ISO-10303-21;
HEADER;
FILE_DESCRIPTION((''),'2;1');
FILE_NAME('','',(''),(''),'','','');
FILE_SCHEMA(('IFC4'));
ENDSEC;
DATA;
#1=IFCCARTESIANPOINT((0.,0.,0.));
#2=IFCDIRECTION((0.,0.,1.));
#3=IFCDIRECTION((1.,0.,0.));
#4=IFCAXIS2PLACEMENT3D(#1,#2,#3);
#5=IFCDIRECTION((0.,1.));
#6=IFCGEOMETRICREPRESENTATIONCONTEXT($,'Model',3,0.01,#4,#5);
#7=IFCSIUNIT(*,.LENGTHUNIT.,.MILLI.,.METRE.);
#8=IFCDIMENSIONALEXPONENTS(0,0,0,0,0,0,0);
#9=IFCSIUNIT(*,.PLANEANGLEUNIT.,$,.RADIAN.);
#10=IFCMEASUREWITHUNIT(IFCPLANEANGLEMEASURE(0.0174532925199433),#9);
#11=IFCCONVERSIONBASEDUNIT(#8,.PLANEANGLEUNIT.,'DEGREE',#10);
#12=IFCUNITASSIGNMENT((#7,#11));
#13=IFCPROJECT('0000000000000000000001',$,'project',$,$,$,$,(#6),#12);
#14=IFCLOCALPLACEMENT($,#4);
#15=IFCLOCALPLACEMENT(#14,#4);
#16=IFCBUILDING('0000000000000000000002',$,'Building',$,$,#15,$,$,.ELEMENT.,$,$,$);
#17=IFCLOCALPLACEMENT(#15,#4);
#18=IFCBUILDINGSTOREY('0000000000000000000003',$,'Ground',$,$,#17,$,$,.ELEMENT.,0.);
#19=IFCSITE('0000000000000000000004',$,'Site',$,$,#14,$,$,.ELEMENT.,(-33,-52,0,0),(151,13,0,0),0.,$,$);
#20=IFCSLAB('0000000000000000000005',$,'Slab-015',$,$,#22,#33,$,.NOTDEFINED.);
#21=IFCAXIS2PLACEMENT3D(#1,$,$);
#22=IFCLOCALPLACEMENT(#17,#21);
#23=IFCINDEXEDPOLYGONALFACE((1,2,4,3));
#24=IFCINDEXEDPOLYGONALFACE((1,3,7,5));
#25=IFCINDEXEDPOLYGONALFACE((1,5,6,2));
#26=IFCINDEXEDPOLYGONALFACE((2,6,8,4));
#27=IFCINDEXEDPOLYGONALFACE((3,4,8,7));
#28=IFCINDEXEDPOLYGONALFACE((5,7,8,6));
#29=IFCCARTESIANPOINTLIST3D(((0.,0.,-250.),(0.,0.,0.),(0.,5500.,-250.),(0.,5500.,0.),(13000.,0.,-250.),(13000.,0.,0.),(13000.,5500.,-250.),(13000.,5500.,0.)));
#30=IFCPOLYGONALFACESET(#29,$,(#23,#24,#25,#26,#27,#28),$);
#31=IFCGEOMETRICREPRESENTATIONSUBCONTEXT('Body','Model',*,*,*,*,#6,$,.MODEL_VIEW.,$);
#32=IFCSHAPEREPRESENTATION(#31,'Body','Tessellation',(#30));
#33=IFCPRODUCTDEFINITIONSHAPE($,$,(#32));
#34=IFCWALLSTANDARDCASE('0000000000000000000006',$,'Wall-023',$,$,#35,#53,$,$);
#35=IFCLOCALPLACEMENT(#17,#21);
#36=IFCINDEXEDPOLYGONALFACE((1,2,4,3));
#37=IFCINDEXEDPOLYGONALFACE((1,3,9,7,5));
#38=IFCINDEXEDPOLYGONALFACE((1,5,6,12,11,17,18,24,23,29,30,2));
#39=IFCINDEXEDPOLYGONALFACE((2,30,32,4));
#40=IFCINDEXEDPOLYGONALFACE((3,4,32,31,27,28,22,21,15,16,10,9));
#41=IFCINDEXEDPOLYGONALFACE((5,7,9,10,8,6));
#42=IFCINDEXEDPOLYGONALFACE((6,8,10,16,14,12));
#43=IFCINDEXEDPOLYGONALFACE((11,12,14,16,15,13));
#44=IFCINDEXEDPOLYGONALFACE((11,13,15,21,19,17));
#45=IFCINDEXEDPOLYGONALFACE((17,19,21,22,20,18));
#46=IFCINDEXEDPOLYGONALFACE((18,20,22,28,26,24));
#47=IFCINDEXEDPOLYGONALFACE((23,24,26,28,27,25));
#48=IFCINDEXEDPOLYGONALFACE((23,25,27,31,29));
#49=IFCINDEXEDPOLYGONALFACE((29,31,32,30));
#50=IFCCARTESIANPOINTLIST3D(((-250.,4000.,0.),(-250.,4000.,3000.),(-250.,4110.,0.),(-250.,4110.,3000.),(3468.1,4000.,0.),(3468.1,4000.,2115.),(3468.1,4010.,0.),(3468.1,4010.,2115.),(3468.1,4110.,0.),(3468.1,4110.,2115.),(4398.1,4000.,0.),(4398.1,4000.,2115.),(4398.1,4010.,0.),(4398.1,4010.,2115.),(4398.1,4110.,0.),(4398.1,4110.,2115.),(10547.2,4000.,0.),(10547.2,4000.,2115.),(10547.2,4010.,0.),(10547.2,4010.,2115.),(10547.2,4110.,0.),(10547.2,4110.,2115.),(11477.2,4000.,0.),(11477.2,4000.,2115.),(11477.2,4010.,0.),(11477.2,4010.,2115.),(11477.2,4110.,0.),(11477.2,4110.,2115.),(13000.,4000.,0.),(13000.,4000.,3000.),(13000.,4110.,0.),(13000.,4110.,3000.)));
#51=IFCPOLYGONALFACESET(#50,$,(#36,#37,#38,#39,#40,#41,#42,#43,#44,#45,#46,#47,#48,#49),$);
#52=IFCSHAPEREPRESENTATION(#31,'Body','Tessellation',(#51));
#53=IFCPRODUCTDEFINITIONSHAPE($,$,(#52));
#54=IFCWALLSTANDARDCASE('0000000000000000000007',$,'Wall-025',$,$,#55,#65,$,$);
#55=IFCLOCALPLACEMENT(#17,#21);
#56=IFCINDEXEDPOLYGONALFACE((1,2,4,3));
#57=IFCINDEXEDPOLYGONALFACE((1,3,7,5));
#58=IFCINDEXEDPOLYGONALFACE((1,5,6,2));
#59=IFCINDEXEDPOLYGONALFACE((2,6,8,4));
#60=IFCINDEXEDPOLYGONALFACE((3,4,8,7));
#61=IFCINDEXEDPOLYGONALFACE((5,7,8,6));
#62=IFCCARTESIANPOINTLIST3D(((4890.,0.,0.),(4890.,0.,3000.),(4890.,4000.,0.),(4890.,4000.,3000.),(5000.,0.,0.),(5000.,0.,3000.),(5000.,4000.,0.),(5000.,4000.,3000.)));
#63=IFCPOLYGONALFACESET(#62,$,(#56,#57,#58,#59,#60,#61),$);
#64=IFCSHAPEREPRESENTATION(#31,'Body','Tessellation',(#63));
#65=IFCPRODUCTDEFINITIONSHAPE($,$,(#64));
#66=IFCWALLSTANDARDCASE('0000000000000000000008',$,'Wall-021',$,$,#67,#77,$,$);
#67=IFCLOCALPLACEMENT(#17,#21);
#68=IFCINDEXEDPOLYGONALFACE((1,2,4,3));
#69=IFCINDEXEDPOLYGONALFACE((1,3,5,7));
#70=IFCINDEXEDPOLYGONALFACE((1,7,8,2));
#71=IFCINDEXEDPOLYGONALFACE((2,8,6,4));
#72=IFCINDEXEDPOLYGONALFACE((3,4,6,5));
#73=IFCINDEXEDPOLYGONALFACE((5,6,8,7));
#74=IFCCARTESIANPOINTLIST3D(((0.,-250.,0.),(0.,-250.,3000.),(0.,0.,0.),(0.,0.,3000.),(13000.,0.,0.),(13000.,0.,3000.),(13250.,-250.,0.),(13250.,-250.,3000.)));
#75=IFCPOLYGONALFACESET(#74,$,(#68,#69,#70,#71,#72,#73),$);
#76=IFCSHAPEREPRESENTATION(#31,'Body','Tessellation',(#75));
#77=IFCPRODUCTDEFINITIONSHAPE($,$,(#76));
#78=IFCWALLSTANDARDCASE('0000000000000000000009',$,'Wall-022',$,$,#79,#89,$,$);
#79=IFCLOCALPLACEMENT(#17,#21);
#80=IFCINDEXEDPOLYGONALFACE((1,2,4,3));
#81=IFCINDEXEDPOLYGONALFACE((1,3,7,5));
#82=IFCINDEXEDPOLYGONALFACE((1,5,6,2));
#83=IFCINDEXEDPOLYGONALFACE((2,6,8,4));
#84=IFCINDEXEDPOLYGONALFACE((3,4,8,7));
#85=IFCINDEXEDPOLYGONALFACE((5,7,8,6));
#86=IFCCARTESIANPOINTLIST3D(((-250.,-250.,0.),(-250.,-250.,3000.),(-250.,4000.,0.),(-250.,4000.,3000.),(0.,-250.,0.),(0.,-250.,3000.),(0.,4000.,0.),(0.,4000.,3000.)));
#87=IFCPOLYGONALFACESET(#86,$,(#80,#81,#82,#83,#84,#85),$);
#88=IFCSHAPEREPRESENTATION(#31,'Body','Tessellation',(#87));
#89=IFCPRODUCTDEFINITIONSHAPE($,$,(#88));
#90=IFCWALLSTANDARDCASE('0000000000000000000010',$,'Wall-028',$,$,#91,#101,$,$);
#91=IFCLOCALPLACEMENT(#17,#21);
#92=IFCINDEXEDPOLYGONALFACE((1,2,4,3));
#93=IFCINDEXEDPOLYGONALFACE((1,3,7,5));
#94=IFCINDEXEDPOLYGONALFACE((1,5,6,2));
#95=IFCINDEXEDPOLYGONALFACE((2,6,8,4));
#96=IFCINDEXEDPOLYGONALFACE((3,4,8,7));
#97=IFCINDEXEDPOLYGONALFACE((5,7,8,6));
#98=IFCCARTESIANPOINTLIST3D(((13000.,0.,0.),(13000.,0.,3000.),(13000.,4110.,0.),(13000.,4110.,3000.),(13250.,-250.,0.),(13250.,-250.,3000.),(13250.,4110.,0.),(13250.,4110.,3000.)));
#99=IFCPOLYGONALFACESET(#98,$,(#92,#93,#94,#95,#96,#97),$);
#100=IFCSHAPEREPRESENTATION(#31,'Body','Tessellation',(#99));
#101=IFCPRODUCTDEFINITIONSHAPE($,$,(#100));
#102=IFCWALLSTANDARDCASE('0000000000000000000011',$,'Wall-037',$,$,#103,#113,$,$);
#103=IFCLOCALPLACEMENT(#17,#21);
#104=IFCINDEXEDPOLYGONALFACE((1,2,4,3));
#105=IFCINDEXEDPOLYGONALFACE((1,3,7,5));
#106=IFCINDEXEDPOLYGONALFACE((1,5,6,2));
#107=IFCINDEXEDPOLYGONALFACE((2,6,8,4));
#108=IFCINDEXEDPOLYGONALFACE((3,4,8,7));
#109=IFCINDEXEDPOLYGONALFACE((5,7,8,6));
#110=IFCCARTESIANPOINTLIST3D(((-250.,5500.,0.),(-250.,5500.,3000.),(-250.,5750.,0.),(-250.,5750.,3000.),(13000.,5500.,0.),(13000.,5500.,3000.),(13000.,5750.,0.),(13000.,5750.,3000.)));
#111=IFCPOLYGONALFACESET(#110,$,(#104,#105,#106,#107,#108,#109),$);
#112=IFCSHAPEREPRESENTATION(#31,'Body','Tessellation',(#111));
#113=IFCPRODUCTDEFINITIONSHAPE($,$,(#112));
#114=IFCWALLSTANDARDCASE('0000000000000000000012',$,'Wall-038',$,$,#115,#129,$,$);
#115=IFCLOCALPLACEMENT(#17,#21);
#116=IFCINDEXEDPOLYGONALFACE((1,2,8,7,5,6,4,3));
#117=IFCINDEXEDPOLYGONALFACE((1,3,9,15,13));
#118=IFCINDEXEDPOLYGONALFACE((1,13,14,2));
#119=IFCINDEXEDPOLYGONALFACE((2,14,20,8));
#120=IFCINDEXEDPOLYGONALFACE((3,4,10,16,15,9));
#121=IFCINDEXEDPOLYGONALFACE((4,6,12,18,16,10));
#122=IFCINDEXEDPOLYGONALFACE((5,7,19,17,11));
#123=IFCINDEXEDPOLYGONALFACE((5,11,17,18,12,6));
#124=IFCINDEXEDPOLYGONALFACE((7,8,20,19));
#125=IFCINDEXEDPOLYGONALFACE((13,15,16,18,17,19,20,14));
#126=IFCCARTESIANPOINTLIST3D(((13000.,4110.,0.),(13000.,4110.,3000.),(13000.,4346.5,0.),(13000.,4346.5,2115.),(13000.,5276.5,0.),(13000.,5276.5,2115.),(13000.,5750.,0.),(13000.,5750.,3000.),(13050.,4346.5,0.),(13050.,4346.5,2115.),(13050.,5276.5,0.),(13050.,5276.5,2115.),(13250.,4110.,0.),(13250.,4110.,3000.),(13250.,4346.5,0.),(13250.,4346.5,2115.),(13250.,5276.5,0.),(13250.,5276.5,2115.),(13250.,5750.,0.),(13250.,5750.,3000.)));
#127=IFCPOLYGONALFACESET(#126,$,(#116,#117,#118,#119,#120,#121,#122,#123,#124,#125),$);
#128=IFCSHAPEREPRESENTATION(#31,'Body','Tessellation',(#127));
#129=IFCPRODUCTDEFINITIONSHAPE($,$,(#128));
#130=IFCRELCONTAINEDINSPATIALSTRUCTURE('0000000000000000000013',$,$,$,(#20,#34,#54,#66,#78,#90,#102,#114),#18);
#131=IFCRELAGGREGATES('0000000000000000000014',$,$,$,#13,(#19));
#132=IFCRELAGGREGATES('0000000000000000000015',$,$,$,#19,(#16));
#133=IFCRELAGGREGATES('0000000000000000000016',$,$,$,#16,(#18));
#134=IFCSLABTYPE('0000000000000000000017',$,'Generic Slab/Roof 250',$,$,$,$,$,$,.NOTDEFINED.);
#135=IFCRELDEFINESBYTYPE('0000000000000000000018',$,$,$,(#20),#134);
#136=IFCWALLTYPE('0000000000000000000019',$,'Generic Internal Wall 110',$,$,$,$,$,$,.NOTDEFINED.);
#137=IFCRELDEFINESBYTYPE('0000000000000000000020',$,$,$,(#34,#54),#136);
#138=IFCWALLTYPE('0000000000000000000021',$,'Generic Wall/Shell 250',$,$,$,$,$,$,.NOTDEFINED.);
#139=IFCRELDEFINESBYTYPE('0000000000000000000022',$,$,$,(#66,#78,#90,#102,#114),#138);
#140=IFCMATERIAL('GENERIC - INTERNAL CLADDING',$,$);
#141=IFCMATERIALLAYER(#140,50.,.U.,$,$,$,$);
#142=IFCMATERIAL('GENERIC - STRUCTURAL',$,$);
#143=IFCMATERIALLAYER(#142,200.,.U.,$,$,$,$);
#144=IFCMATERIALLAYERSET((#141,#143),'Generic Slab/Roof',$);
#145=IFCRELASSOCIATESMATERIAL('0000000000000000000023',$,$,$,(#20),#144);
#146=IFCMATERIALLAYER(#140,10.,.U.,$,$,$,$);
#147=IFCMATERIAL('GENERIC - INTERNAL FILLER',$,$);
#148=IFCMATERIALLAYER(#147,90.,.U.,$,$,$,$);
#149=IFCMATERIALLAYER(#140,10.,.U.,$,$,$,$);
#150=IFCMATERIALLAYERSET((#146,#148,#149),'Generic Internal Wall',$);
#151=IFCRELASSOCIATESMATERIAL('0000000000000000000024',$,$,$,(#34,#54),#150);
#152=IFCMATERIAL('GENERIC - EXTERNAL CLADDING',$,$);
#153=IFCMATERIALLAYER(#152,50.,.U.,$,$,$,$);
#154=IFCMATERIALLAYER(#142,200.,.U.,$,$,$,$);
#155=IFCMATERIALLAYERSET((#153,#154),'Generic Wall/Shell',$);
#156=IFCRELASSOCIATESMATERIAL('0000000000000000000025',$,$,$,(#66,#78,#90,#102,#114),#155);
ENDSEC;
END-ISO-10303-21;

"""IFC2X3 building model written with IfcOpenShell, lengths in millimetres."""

from ifc_helpers import new_model, entity, si_unit, converted_unit, direction, frame, origin_with_axes, origin_2d_with_axis, place, context, subcontext, project, spatial, polyline, rectangle, outline, extrude, material, layer, layer_set, layer_usage, type_object, element, save


model = new_model("IFC2X3")

# Units and contexts
model_context = context("Model", 3, precision=0.01, world=origin_with_axes(), true_north=direction((0.0, 1.0)))
body_context = subcontext(model_context, "Body", "Model", "MODEL_VIEW")
ifc_project = project(units=[si_unit("LENGTHUNIT", "METRE", prefix="MILLI"), converted_unit("PLANEANGLEUNIT", "DEGREE", entity("IfcPlaneAngleMeasure", 0.0174532925199433), si_unit("PLANEANGLEUNIT", "RADIAN"), dimensions=[0, 0, 0, 0, 0, 0, 0])], contexts=[model_context])

# Site, building, storey
site_placement = place(None, origin_with_axes())
site = spatial("IfcSite", under=ifc_project, at=site_placement, Name="Site", CompositionType="ELEMENT", RefLatitude=(-33, -52, 0, 0), RefLongitude=(151, 13, 0, 0), RefElevation=0.0)
building_placement = place(site_placement, origin_with_axes())
building = spatial("IfcBuilding", under=site, at=building_placement, Name="Building", CompositionType="ELEMENT")
storey_placement = place(building_placement, origin_with_axes())
storey = spatial("IfcBuildingStorey", under=building, at=storey_placement, Name="Ground", CompositionType="ELEMENT", Elevation=0.0)

# Slab
ifc_material_1 = material(Name="GENERIC - INTERNAL CLADDING")
ifc_layer_1 = layer(ifc_material_1, 50.0, ventilated="UNKNOWN")
ifc_material_2 = material(Name="GENERIC - STRUCTURAL")
ifc_layer_2 = layer(ifc_material_2, 200.0, ventilated="UNKNOWN")
ifc_layer_set_1 = layer_set([ifc_layer_1, ifc_layer_2], Name="Generic Slab/Roof")
ifc_layer_usage_1 = layer_usage(ifc_layer_set_1, "AXIS3", "NEGATIVE", 250.0)
slab_type = type_object("IfcSlabType", Name="Generic Slab/Roof 250", PredefinedType="NOTDEFINED")
slab_placement = place(storey_placement, origin_with_axes())
element("IfcSlab", 1, at=slab_placement, inside=storey, type_object=slab_type, material=ifc_layer_usage_1, Name="Slab-015", PredefinedType="NOTDEFINED", context=body_context, shape_type="SweptSolid", body=[
    extrude(outline(polyline([(0.0, 0.0), (13000.0, 0.0), (13000.0, 5500.0), (0.0, 5500.0), (0.0, 0.0)])), frame((0.0, 0.0, -250.0), z_axis=(0.0, 0.0, 1.0), x_axis=(1.0, 0.0, 0.0)), (0.0, 0.0, 1.0), 250.0),
])

# Wall, openings
ifc_layer_3 = layer(ifc_material_1, 10.0, ventilated="UNKNOWN")
ifc_material_3 = material(Name="GENERIC - INTERNAL FILLER")
ifc_layer_4 = layer(ifc_material_3, 90.0, ventilated="UNKNOWN")
ifc_layer_5 = layer(ifc_material_1, 10.0, ventilated="UNKNOWN")
ifc_layer_set_2 = layer_set([ifc_layer_3, ifc_layer_4, ifc_layer_5], Name="Generic Internal Wall")
ifc_layer_usage_2 = layer_usage(ifc_layer_set_2, "AXIS2", "POSITIVE", 0.0)
wall_type_1 = type_object("IfcWallType", Name="Generic Internal Wall 110", PredefinedType="NOTDEFINED")
wall_1_placement = place(storey_placement, frame((-250.0, 4000.0, 0.0), z_axis=(0.0, 0.0, 1.0), x_axis=(1.0, 0.0, 0.0)))
wall_1 = element("IfcWallStandardCase", 2, at=wall_1_placement, inside=storey, type_object=wall_type_1, material=ifc_layer_usage_2, Name="Wall-023", context=body_context, shape_type="SweptSolid", body=[
    extrude(outline(polyline([(0.0, 0.0), (13250.0, 0.0), (13250.0, 110.0), (0.0, 110.0), (0.0, 0.0)])), origin_with_axes(), (0.0, 0.0, 1.0), 3000.0),
])
opening_1_placement = place(wall_1_placement, frame((4183.1, 0.0, 0.0), z_axis=(0.0, 0.0, 1.0), x_axis=(1.0, 0.0, 0.0)))
element("IfcOpeningElement", 3, at=opening_1_placement, cuts=wall_1, context=body_context, shape_type="SweptSolid", body=[
    extrude(rectangle(XDim=930.0, YDim=2115.0, at=origin_2d_with_axis()), frame((0.0, 10.0, 1057.5), z_axis=(0.0, 1.0, 0.0), x_axis=(1.0, 0.0, 0.0)), (0.0, 0.0, 1.0), 210.0),
    extrude(rectangle(XDim=930.0, YDim=2115.0, at=origin_2d_with_axis()), frame((0.0, 10.0, 1057.5), z_axis=(0.0, -1.0, 0.0), x_axis=(1.0, 0.0, 0.0)), (0.0, 0.0, 1.0), 120.0),
])
opening_2_placement = place(wall_1_placement, frame((11262.2, 0.0, 0.0), z_axis=(0.0, 0.0, 1.0), x_axis=(1.0, 0.0, 0.0)))
element("IfcOpeningElement", 4, at=opening_2_placement, cuts=wall_1, context=body_context, shape_type="SweptSolid", body=[
    extrude(rectangle(XDim=930.0, YDim=2115.0, at=origin_2d_with_axis()), frame((0.0, 10.0, 1057.5), z_axis=(0.0, 1.0, 0.0), x_axis=(1.0, 0.0, 0.0)), (0.0, 0.0, 1.0), 210.0),
    extrude(rectangle(XDim=930.0, YDim=2115.0, at=origin_2d_with_axis()), frame((0.0, 10.0, 1057.5), z_axis=(0.0, -1.0, 0.0), x_axis=(1.0, 0.0, 0.0)), (0.0, 0.0, 1.0), 120.0),
])

# Walls
ifc_layer_usage_3 = layer_usage(ifc_layer_set_2, "AXIS2", "POSITIVE", 0.0)
wall_2_placement = place(storey_placement, frame((5000.0, 0.0, 0.0), z_axis=(0.0, 0.0, 1.0), x_axis=(0.0, 1.0, 0.0)))
element("IfcWallStandardCase", 5, at=wall_2_placement, inside=storey, type_object=wall_type_1, material=ifc_layer_usage_3, Name="Wall-025", context=body_context, shape_type="SweptSolid", body=[
    extrude(outline(polyline([(0.0, 0.0), (4000.0, 0.0), (4000.0, 110.0), (0.0, 110.0), (0.0, 0.0)])), origin_with_axes(), (0.0, 0.0, 1.0), 3000.0),
])
ifc_material_4 = material(Name="GENERIC - EXTERNAL CLADDING")
ifc_layer_6 = layer(ifc_material_4, 50.0, ventilated="UNKNOWN")
ifc_layer_7 = layer(ifc_material_2, 200.0, ventilated="UNKNOWN")
ifc_layer_set_3 = layer_set([ifc_layer_6, ifc_layer_7], Name="Generic Wall/Shell")
ifc_layer_usage_4 = layer_usage(ifc_layer_set_3, "AXIS2", "POSITIVE", 0.0)
wall_type_2 = type_object("IfcWallType", Name="Generic Wall/Shell 250", PredefinedType="NOTDEFINED")
wall_3_placement = place(storey_placement, frame((13000.0, 0.0, 0.0), z_axis=(0.0, 0.0, 1.0), x_axis=(-1.0, 0.0, 0.0)))
element("IfcWallStandardCase", 6, at=wall_3_placement, inside=storey, type_object=wall_type_2, material=ifc_layer_usage_4, Name="Wall-021", context=body_context, shape_type="SweptSolid", body=[
    extrude(outline(polyline([(0.0, 0.0), (13000.0, 0.0), (13000.0, 250.0), (-250.0, 250.0), (0.0, 0.0)])), origin_with_axes(), (0.0, 0.0, 1.0), 3000.0),
])
ifc_layer_usage_5 = layer_usage(ifc_layer_set_3, "AXIS2", "POSITIVE", 0.0)
wall_4_placement = place(storey_placement, frame((0.0, -250.0, 0.0), z_axis=(0.0, 0.0, 1.0), x_axis=(0.0, 1.0, 0.0)))
element("IfcWallStandardCase", 7, at=wall_4_placement, inside=storey, type_object=wall_type_2, material=ifc_layer_usage_5, Name="Wall-022", context=body_context, shape_type="SweptSolid", body=[
    extrude(outline(polyline([(0.0, 0.0), (4250.0, 0.0), (4250.0, 250.0), (0.0, 250.0), (0.0, 0.0)])), origin_with_axes(), (0.0, 0.0, 1.0), 3000.0),
])
ifc_layer_usage_6 = layer_usage(ifc_layer_set_3, "AXIS2", "POSITIVE", 0.0)
wall_5_placement = place(storey_placement, frame((13000.0, 4110.0, 0.0), z_axis=(0.0, 0.0, 1.0), x_axis=(0.0, -1.0, 0.0)))
element("IfcWallStandardCase", 8, at=wall_5_placement, inside=storey, type_object=wall_type_2, material=ifc_layer_usage_6, Name="Wall-028", context=body_context, shape_type="SweptSolid", body=[
    extrude(outline(polyline([(0.0, 0.0), (4110.0, 0.0), (4360.0, 250.0), (0.0, 250.0), (0.0, 0.0)])), origin_with_axes(), (0.0, 0.0, 1.0), 3000.0),
])
ifc_layer_usage_7 = layer_usage(ifc_layer_set_3, "AXIS2", "POSITIVE", 0.0)
wall_6_placement = place(storey_placement, frame((-250.0, 5500.0, 0.0), z_axis=(0.0, 0.0, 1.0), x_axis=(1.0, 0.0, 0.0)))
element("IfcWallStandardCase", 9, at=wall_6_placement, inside=storey, type_object=wall_type_2, material=ifc_layer_usage_7, Name="Wall-037", context=body_context, shape_type="SweptSolid", body=[
    extrude(outline(polyline([(0.0, 0.0), (13250.0, 0.0), (13250.0, 250.0), (0.0, 250.0), (0.0, 0.0)])), origin_with_axes(), (0.0, 0.0, 1.0), 3000.0),
])

# Wall, opening
ifc_layer_usage_8 = layer_usage(ifc_layer_set_3, "AXIS2", "POSITIVE", 0.0)
wall_7_placement = place(storey_placement, frame((13000.0, 5750.0, 0.0), z_axis=(0.0, 0.0, 1.0), x_axis=(0.0, -1.0, 0.0)))
wall_7 = element("IfcWallStandardCase", 10, at=wall_7_placement, inside=storey, type_object=wall_type_2, material=ifc_layer_usage_8, Name="Wall-038", context=body_context, shape_type="SweptSolid", body=[
    extrude(outline(polyline([(0.0, 0.0), (1640.0, 0.0), (1640.0, 250.0), (0.0, 250.0), (0.0, 0.0)])), origin_with_axes(), (0.0, 0.0, 1.0), 3000.0),
])
opening_3_placement = place(wall_7_placement, frame((938.5, 0.0, 0.0), z_axis=(0.0, 0.0, 1.0), x_axis=(1.0, 0.0, 0.0)))
element("IfcOpeningElement", 11, at=opening_3_placement, cuts=wall_7, context=body_context, shape_type="SweptSolid", body=[
    extrude(rectangle(XDim=930.0, YDim=2115.0, at=origin_2d_with_axis()), frame((0.0, 50.0, 1057.5), z_axis=(0.0, -1.0, 0.0), x_axis=(1.0, 0.0, 0.0)), (0.0, 0.0, -1.0), 450.0),
    extrude(rectangle(XDim=930.0, YDim=2115.0, at=origin_2d_with_axis()), frame((0.0, 50.0, 1057.5), z_axis=(0.0, 1.0, 0.0), x_axis=(1.0, 0.0, 0.0)), (0.0, 0.0, -1.0), 300.0),
])

save(model, "model.ifc")
